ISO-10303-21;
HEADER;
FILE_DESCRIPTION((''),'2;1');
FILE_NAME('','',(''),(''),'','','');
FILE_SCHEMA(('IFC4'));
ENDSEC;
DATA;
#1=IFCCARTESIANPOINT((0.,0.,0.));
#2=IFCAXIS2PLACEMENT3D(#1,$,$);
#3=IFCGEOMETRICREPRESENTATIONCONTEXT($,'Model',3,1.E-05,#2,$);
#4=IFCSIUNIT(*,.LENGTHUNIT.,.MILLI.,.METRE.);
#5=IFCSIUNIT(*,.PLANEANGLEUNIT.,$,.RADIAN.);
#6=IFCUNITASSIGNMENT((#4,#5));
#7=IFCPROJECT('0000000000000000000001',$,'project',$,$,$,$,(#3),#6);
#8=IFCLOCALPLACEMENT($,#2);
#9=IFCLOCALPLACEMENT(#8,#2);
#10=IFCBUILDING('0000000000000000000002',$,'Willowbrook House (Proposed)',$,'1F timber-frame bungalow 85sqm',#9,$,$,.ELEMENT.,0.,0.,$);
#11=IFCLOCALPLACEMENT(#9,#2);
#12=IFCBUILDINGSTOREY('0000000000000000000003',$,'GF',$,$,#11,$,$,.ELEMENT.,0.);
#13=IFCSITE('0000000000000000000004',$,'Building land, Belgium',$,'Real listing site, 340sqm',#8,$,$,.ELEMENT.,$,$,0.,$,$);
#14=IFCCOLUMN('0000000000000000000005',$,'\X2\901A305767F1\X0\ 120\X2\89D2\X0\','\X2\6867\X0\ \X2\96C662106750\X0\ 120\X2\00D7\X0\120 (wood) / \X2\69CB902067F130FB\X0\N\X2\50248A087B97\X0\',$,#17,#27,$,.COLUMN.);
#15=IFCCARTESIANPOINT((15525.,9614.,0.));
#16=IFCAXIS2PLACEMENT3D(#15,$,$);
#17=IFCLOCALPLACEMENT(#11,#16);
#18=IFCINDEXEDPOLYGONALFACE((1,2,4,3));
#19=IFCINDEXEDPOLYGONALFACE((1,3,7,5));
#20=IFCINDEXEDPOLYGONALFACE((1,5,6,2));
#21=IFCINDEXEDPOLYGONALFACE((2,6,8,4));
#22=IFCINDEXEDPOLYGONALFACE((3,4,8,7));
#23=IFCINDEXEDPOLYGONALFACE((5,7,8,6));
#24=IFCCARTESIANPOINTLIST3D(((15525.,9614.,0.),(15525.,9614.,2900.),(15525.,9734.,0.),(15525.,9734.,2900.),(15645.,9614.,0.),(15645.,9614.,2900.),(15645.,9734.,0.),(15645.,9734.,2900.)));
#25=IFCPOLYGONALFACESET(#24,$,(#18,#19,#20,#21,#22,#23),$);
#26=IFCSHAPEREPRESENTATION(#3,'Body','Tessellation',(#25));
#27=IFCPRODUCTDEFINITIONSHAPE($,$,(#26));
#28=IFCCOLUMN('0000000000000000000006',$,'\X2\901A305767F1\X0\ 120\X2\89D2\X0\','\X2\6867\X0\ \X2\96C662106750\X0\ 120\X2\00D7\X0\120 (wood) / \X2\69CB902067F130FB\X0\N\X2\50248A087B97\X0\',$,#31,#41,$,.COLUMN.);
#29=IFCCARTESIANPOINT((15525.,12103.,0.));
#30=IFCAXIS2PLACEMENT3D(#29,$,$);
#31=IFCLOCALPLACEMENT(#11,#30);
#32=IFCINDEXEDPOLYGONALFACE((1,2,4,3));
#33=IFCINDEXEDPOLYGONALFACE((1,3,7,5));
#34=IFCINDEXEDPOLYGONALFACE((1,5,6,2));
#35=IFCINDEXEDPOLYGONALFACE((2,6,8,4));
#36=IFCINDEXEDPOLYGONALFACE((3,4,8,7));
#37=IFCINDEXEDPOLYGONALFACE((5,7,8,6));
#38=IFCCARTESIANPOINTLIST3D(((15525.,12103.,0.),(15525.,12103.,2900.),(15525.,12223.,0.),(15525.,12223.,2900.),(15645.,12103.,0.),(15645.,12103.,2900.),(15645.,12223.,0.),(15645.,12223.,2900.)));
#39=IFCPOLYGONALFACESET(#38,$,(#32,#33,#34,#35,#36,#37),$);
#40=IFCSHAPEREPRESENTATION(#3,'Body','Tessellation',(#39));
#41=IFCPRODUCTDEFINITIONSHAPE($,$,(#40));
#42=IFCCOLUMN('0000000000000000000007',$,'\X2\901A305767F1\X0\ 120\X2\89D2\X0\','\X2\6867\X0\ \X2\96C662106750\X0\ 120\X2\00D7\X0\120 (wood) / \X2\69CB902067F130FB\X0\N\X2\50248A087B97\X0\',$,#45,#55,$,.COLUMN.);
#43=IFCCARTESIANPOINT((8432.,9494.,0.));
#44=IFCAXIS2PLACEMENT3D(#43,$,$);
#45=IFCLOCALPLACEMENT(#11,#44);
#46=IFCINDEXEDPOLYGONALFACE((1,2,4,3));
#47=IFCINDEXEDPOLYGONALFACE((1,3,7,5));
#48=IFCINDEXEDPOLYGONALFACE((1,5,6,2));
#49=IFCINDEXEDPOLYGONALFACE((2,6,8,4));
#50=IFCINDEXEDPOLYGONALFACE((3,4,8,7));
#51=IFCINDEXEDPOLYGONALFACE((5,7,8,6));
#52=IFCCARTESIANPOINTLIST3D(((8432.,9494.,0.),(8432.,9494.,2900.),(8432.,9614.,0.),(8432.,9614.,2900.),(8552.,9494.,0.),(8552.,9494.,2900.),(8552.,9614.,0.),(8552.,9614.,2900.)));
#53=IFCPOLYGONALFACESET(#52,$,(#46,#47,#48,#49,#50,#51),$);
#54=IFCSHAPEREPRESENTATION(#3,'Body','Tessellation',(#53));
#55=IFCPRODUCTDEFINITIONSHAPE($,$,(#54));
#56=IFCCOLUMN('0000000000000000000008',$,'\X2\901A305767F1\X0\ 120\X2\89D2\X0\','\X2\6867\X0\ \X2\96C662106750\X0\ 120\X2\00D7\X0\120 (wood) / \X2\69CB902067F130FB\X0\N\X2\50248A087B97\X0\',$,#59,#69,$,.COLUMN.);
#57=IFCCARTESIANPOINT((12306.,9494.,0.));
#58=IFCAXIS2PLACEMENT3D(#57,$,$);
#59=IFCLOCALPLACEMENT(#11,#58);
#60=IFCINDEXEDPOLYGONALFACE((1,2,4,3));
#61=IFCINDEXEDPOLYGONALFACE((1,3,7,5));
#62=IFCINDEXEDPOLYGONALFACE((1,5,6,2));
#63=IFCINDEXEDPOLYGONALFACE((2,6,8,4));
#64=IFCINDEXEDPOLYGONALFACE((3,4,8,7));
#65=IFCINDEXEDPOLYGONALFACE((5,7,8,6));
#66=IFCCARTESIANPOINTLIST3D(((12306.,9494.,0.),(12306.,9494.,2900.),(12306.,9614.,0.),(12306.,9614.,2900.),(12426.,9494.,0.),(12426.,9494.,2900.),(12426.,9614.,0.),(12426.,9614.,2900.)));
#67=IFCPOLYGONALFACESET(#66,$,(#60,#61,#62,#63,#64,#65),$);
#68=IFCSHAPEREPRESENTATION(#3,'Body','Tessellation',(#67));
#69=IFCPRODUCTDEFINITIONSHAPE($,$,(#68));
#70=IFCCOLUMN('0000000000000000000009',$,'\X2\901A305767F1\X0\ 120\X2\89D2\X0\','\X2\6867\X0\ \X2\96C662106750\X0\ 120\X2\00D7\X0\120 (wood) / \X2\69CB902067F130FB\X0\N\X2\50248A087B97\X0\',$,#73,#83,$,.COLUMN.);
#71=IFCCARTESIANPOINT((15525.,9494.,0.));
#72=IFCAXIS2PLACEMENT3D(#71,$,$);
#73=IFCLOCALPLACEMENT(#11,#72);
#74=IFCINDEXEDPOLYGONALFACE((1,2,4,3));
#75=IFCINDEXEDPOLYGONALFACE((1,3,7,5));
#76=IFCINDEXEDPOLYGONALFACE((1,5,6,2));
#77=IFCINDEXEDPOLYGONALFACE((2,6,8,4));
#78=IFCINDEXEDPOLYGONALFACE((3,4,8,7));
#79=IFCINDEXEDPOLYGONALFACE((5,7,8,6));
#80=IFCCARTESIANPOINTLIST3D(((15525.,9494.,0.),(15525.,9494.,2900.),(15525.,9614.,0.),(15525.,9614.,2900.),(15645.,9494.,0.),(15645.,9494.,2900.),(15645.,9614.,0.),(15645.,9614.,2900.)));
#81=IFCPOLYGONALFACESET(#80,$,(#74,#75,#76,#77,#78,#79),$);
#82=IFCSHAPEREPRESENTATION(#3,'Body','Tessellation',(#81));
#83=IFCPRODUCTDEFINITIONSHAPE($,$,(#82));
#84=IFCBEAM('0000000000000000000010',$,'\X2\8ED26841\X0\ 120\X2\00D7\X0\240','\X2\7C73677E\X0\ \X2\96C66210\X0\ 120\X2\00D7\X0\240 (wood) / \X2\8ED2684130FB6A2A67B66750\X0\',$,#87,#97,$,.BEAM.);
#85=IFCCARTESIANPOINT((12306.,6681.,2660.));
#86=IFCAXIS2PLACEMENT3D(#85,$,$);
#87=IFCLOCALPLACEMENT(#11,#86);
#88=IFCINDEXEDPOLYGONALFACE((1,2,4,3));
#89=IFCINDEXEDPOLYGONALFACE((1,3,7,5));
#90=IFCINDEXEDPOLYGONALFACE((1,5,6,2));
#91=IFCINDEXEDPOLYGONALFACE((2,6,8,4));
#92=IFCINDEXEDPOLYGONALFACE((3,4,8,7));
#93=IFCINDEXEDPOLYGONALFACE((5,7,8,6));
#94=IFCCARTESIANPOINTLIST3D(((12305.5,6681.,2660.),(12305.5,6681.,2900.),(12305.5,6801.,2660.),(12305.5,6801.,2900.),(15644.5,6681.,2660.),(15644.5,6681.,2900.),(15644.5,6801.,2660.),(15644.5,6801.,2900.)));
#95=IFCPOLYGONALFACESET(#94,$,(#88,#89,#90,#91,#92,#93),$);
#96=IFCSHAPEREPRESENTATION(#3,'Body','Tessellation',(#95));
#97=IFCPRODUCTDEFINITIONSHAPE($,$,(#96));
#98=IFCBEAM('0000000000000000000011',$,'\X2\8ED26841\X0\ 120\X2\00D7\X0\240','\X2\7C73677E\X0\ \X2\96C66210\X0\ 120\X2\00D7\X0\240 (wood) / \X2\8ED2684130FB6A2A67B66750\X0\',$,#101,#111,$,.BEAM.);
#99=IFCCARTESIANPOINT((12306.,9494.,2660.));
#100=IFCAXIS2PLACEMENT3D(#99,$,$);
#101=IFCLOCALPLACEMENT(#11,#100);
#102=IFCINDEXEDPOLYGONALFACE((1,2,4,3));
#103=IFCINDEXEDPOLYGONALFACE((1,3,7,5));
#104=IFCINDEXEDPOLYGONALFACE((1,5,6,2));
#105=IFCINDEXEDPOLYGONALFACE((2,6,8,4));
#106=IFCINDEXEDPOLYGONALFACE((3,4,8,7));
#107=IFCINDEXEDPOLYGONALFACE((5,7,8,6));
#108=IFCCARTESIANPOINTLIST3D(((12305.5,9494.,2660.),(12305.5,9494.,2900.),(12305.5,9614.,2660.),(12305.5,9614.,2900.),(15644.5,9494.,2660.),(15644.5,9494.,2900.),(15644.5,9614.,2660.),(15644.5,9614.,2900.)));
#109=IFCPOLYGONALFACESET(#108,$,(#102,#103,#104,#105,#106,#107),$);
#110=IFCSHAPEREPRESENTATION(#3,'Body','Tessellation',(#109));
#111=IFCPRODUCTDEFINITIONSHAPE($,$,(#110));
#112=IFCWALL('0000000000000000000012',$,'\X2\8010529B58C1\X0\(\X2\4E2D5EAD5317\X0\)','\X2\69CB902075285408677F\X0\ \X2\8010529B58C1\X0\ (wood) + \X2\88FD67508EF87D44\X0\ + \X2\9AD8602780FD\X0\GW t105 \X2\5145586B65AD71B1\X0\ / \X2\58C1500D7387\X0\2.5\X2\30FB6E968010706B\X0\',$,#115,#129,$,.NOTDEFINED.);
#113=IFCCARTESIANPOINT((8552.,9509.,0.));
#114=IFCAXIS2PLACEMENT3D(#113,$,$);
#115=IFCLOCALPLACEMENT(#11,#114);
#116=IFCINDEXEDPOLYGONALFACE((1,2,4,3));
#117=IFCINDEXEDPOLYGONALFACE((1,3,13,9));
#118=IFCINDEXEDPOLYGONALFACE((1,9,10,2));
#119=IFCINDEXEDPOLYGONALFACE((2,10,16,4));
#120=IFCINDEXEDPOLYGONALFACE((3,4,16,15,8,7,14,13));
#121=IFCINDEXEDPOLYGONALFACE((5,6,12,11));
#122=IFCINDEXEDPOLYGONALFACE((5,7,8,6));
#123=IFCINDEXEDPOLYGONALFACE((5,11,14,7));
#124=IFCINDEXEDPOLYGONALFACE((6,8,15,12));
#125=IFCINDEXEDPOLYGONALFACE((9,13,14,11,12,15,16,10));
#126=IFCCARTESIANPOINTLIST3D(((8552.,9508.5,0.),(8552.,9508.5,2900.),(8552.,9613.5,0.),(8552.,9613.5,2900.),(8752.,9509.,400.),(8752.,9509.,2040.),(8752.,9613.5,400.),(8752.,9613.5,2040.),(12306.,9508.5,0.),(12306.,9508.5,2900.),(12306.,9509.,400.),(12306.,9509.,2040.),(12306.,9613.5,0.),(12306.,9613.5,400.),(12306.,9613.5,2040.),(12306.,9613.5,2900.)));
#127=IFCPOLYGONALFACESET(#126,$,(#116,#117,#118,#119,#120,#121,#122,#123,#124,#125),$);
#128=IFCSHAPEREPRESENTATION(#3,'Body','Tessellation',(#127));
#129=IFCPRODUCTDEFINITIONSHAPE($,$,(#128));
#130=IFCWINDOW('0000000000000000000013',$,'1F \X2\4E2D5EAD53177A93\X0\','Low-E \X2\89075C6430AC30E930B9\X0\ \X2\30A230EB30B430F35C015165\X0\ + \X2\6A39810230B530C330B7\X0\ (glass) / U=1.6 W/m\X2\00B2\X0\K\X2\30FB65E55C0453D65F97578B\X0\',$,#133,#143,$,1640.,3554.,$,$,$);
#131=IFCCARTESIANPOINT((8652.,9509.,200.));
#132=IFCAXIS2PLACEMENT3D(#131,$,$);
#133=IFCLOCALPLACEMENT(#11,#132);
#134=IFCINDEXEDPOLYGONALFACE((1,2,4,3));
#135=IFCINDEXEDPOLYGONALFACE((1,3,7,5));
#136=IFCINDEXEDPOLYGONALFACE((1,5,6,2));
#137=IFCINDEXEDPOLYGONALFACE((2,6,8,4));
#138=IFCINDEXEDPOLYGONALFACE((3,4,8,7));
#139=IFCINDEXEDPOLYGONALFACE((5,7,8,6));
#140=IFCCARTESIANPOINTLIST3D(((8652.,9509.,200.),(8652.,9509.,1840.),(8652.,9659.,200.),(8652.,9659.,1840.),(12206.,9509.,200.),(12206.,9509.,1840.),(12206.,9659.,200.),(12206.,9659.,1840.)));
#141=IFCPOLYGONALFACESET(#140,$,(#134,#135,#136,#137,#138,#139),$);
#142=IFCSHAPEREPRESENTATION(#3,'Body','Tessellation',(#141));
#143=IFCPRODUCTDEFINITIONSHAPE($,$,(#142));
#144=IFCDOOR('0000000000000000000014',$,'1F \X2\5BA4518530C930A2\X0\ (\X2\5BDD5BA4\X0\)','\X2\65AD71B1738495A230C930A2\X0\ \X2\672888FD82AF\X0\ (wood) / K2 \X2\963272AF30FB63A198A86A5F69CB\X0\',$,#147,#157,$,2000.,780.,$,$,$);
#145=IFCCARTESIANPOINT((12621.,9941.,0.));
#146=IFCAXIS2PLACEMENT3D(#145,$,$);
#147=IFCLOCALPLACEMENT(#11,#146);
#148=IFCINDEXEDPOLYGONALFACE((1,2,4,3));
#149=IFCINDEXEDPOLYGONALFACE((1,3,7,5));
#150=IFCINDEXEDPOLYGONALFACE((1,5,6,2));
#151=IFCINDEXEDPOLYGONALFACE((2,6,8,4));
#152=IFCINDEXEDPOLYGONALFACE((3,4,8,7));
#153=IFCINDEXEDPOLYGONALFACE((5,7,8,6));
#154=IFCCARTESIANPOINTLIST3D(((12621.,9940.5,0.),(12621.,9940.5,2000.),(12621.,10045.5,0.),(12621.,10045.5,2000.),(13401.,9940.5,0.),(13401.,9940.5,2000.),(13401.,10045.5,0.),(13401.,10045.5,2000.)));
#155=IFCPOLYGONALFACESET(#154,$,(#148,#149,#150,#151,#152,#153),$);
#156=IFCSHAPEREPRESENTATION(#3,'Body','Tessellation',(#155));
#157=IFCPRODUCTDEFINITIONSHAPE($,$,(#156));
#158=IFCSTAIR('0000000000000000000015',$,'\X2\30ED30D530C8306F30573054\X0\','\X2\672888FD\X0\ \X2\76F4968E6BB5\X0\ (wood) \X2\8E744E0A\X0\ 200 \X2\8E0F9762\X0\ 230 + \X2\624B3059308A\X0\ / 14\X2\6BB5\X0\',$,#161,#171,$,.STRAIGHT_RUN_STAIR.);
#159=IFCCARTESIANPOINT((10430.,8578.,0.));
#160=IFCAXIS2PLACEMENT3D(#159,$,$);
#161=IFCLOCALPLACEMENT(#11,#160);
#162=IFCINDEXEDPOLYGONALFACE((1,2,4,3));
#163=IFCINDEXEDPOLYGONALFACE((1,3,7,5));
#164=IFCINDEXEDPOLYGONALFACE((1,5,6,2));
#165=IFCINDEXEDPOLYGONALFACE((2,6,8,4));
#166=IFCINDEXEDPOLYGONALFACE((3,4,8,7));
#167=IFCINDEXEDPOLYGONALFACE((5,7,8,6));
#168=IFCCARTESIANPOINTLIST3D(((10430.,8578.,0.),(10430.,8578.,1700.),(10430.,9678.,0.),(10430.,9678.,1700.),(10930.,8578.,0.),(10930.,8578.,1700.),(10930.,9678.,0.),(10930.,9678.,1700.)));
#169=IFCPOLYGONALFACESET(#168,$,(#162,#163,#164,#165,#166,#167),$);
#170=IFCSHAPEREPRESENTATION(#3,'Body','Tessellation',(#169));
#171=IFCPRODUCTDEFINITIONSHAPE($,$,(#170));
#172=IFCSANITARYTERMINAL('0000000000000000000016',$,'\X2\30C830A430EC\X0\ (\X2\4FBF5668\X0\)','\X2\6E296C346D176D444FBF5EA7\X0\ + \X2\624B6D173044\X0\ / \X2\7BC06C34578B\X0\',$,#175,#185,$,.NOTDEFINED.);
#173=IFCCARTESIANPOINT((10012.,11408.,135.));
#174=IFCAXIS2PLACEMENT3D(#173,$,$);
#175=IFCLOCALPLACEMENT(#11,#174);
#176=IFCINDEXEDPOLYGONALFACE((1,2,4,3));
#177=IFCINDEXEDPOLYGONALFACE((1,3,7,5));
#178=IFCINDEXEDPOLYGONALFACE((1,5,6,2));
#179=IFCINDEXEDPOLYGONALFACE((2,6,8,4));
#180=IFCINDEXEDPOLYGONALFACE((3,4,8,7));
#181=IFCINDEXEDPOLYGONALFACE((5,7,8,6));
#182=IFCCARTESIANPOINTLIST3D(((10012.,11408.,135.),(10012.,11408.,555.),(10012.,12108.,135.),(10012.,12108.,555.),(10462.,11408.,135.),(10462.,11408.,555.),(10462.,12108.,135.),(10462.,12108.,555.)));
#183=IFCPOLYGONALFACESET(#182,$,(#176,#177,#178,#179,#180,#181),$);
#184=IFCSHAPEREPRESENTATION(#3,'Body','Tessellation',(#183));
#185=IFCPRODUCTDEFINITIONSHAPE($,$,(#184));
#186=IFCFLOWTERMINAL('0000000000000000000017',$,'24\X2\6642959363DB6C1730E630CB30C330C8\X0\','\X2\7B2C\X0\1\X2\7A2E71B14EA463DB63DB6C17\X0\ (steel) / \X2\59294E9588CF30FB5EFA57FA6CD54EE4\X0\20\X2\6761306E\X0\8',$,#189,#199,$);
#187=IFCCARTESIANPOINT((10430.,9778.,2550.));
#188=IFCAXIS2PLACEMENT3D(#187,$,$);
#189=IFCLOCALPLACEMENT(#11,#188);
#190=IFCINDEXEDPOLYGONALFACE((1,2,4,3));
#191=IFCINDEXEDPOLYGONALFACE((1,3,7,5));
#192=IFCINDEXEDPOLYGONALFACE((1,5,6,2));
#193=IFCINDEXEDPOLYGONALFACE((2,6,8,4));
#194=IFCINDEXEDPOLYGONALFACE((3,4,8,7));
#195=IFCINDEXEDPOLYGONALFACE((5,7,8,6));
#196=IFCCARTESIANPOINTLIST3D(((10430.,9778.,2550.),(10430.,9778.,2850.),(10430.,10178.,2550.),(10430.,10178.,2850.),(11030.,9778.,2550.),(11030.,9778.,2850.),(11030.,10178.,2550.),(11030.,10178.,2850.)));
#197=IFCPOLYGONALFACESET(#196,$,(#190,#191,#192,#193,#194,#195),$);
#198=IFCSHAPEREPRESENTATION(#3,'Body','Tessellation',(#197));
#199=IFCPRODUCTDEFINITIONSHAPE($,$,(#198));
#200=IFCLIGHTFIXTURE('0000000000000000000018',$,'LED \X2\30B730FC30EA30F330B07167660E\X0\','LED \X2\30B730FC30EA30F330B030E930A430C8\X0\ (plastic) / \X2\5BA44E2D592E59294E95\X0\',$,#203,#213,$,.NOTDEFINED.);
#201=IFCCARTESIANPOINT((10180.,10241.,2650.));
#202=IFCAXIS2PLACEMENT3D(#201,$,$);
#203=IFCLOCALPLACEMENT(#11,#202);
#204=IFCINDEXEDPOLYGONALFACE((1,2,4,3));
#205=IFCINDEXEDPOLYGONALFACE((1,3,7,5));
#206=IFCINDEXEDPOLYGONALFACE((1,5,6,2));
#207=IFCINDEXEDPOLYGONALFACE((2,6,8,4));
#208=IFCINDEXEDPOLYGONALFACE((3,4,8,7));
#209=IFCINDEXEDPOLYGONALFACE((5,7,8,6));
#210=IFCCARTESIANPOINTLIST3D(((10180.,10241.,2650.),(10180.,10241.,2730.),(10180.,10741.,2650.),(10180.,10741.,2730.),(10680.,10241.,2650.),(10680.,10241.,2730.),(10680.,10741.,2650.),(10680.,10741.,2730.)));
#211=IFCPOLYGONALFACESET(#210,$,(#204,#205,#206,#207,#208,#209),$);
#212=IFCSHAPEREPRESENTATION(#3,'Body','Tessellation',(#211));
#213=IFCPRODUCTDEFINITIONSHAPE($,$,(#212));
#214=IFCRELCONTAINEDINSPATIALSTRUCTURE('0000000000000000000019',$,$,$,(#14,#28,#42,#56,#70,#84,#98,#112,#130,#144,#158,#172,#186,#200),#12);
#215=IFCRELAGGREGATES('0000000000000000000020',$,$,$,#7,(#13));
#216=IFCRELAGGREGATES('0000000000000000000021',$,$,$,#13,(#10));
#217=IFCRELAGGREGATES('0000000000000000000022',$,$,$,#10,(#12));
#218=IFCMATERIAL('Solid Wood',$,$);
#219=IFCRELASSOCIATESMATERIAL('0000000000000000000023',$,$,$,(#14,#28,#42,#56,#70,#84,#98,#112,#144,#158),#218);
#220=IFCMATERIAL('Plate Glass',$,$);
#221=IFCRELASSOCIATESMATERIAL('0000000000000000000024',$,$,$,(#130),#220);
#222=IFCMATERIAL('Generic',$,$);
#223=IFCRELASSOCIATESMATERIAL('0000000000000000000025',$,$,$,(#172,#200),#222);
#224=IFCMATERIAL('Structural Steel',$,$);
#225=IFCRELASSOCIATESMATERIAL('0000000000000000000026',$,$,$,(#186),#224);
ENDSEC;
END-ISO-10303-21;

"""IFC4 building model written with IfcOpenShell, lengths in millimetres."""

from ifc_helpers import new_model, si_unit, frame, frame_2d, origin, place, context, project, spatial, rectangle, extrude, material, element, fill, save


model = new_model("IFC4")

# Units and contexts
model_context = context("Model", 3, precision=1e-05, world=origin())
ifc_project = project(units=[si_unit("LENGTHUNIT", "METRE", prefix="MILLI"), si_unit("PLANEANGLEUNIT", "RADIAN")], contexts=[model_context])

# Site, building, storey
site_placement = place(None, origin())
site = spatial("IfcSite", under=ifc_project, at=site_placement, Name="Building land, Belgium", ObjectType="Real listing site, 340sqm", CompositionType="ELEMENT", RefElevation=0.0)
building_placement = place(site_placement, origin())
building = spatial("IfcBuilding", under=site, at=building_placement, Name="Willowbrook House (Proposed)", ObjectType="1F timber-frame bungalow 85sqm", CompositionType="ELEMENT", ElevationOfRefHeight=0.0, ElevationOfTerrain=0.0)
storey_placement = place(building_placement, origin())
storey = spatial("IfcBuildingStorey", under=building, at=storey_placement, Name="GF", CompositionType="ELEMENT", Elevation=0.0)

# Columns
ifc_material_1 = material(Name="Solid Wood")
column_1_placement = place(storey_placement, frame((15525.0, 9614.0, 0.0)))
element("IfcColumn", 1, at=column_1_placement, inside=storey, material=ifc_material_1, Name="通し柱 120角", Description="桧 集成材 120×120 (wood) / 構造柱・N値計算", PredefinedType="COLUMN", context=model_context, shape_type="SweptSolid", body=[
    extrude(rectangle(XDim=120.0, YDim=120.0, at=frame_2d((60.0, 60.0))), frame((15525.0, 9614.0, 0.0)), (0.0, 0.0, 1.0), 2900.0),
])
column_2_placement = place(storey_placement, frame((15525.0, 12103.0, 0.0)))
element("IfcColumn", 2, at=column_2_placement, inside=storey, material=ifc_material_1, Name="通し柱 120角", Description="桧 集成材 120×120 (wood) / 構造柱・N値計算", PredefinedType="COLUMN", context=model_context, shape_type="SweptSolid", body=[
    extrude(rectangle(XDim=120.0, YDim=120.0, at=frame_2d((60.0, 60.0))), frame((15525.0, 12103.0, 0.0)), (0.0, 0.0, 1.0), 2900.0),
])
column_3_placement = place(storey_placement, frame((8432.0, 9494.0, 0.0)))
element("IfcColumn", 3, at=column_3_placement, inside=storey, material=ifc_material_1, Name="通し柱 120角", Description="桧 集成材 120×120 (wood) / 構造柱・N値計算", PredefinedType="COLUMN", context=model_context, shape_type="SweptSolid", body=[
    extrude(rectangle(XDim=120.0, YDim=120.0, at=frame_2d((60.0, 60.0))), frame((8432.0, 9494.0, 0.0)), (0.0, 0.0, 1.0), 2900.0),
])
column_4_placement = place(storey_placement, frame((12306.0, 9494.0, 0.0)))
element("IfcColumn", 4, at=column_4_placement, inside=storey, material=ifc_material_1, Name="通し柱 120角", Description="桧 集成材 120×120 (wood) / 構造柱・N値計算", PredefinedType="COLUMN", context=model_context, shape_type="SweptSolid", body=[
    extrude(rectangle(XDim=120.0, YDim=120.0, at=frame_2d((60.0, 60.0))), frame((12306.0, 9494.0, 0.0)), (0.0, 0.0, 1.0), 2900.0),
])
column_5_placement = place(storey_placement, frame((15525.0, 9494.0, 0.0)))
element("IfcColumn", 5, at=column_5_placement, inside=storey, material=ifc_material_1, Name="通し柱 120角", Description="桧 集成材 120×120 (wood) / 構造柱・N値計算", PredefinedType="COLUMN", context=model_context, shape_type="SweptSolid", body=[
    extrude(rectangle(XDim=120.0, YDim=120.0, at=frame_2d((60.0, 60.0))), frame((15525.0, 9494.0, 0.0)), (0.0, 0.0, 1.0), 2900.0),
])

# Beams
beam_1_placement = place(storey_placement, frame((12306.0, 6681.0, 2660.0)))
element("IfcBeam", 6, at=beam_1_placement, inside=storey, material=ifc_material_1, Name="軒桁 120×240", Description="米松 集成 120×240 (wood) / 軒桁・横架材", PredefinedType="BEAM", context=model_context, shape_type="SweptSolid", body=[
    extrude(rectangle(XDim=3339.0, YDim=120.0, at=frame_2d((1669.0, 60.0))), frame((12306.0, 6681.0, 2660.0)), (0.0, 0.0, 1.0), 240.0),
])
beam_2_placement = place(storey_placement, frame((12306.0, 9494.0, 2660.0)))
element("IfcBeam", 7, at=beam_2_placement, inside=storey, material=ifc_material_1, Name="軒桁 120×240", Description="米松 集成 120×240 (wood) / 軒桁・横架材", PredefinedType="BEAM", context=model_context, shape_type="SweptSolid", body=[
    extrude(rectangle(XDim=3339.0, YDim=120.0, at=frame_2d((1669.0, 60.0))), frame((12306.0, 9494.0, 2660.0)), (0.0, 0.0, 1.0), 240.0),
])

# Wall, opening, window
wall_1_placement = place(storey_placement, frame((8552.0, 9509.0, 0.0)))
wall_1 = element("IfcWall", 8, at=wall_1_placement, inside=storey, material=ifc_material_1, Name="耐力壁(中庭北)", Description="構造用合板 耐力壁 (wood) + 製材軸組 + 高性能GW t105 充填断熱 / 壁倍率2.5・準耐火", PredefinedType="NOTDEFINED", context=model_context, shape_type="SweptSolid", body=[
    extrude(rectangle(XDim=3754.0, YDim=105.0, at=frame_2d((1877.0, 52.0))), frame((8552.0, 9509.0, 0.0)), (0.0, 0.0, 1.0), 2900.0),
])
opening_placement = place(storey_placement, frame((8652.0, 9509.0, 200.0)))
opening = element("IfcOpeningElement", 9, at=opening_placement, cuts=wall_1, PredefinedType="NOTDEFINED", context=model_context, shape_type="SweptSolid", body=[
    extrude(rectangle(XDim=3554.0, YDim=150.0, at=frame_2d((1777.0, 75.0))), frame((8652.0, 9509.0, 200.0)), (0.0, 0.0, 1.0), 1640.0),
])
ifc_material_2 = material(Name="Plate Glass")
window_placement = place(storey_placement, frame((8652.0, 9509.0, 200.0)))
window = element("IfcWindow", 10, at=window_placement, inside=storey, material=ifc_material_2, Name="1F 中庭北窓", Description="Low-E 複層ガラス アルゴン封入 + 樹脂サッシ (glass) / U=1.6 W/m²K・日射取得型", OverallHeight=1640.0, OverallWidth=3554.0, context=model_context, shape_type="SweptSolid", body=[
    extrude(rectangle(XDim=3554.0, YDim=150.0, at=frame_2d((1777.0, 75.0))), frame((8652.0, 9509.0, 200.0)), (0.0, 0.0, 1.0), 1640.0),
])
fill(opening, window)

# Door
door_placement = place(storey_placement, frame((12621.0, 9941.0, 0.0)))
element("IfcDoor", 11, at=door_placement, inside=storey, material=ifc_material_1, Name="1F 室内ドア (寝室)", Description="断熱玄関ドア 木製芯 (wood) / K2 防犯・採風機構", OverallHeight=2000.0, OverallWidth=780.0, context=model_context, shape_type="SweptSolid", body=[
    extrude(rectangle(XDim=780.0, YDim=105.0, at=frame_2d((390.0, 52.0))), frame((12621.0, 9941.0, 0.0)), (0.0, 0.0, 1.0), 2000.0),
])

# Stair
stair_placement = place(storey_placement, frame((10430.0, 8578.0, 0.0)))
element("IfcStair", 12, at=stair_placement, inside=storey, material=ifc_material_1, Name="ロフトはしご", Description="木製 直階段 (wood) 蹴上 200 踏面 230 + 手すり / 14段", PredefinedType="STRAIGHT_RUN_STAIR", context=model_context, shape_type="SweptSolid", body=[
    extrude(rectangle(XDim=500.0, YDim=1100.0, at=frame_2d((250.0, 550.0))), frame((10430.0, 8578.0, 0.0)), (0.0, 0.0, 1.0), 1700.0),
])

# Shared definitions
ifc_material_3 = material(Name="Generic")

# Sanitary terminal
sanitary_terminal_placement = place(storey_placement, frame((10012.0, 11408.0, 135.0)))
element("IfcSanitaryTerminal", 13, at=sanitary_terminal_placement, inside=storey, material=ifc_material_3, Name="トイレ (便器)", Description="温水洗浄便座 + 手洗い / 節水型", PredefinedType="NOTDEFINED", context=model_context, shape_type="SweptSolid", body=[
    extrude(rectangle(XDim=450.0, YDim=700.0, at=frame_2d((225.0, 350.0))), frame((10012.0, 11408.0, 135.0)), (0.0, 0.0, 1.0), 420.0),
])

# Flow terminal
ifc_material_4 = material(Name="Structural Steel")
flow_terminal_placement = place(storey_placement, frame((10430.0, 9778.0, 2550.0)))
element("IfcFlowTerminal", 14, at=flow_terminal_placement, inside=storey, material=ifc_material_4, Name="24時間換気ユニット", Description="第1種熱交換換気 (steel) / 天井裏・建基法令20条の8", context=model_context, shape_type="SweptSolid", body=[
    extrude(rectangle(XDim=600.0, YDim=400.0, at=frame_2d((300.0, 200.0))), frame((10430.0, 9778.0, 2550.0)), (0.0, 0.0, 1.0), 300.0),
])

# Light fixture
light_fixture_1_placement = place(storey_placement, frame((10180.0, 10241.0, 2650.0)))
element("IfcLightFixture", 15, at=light_fixture_1_placement, inside=storey, material=ifc_material_3, Name="LED シーリング照明", Description="LED シーリングライト (plastic) / 室中央天井", PredefinedType="NOTDEFINED", context=model_context, shape_type="SweptSolid", body=[
    extrude(rectangle(XDim=500.0, YDim=500.0, at=frame_2d((250.0, 250.0))), frame((10180.0, 10241.0, 2650.0)), (0.0, 0.0, 1.0), 80.0),
])

save(model, "model.ifc")
